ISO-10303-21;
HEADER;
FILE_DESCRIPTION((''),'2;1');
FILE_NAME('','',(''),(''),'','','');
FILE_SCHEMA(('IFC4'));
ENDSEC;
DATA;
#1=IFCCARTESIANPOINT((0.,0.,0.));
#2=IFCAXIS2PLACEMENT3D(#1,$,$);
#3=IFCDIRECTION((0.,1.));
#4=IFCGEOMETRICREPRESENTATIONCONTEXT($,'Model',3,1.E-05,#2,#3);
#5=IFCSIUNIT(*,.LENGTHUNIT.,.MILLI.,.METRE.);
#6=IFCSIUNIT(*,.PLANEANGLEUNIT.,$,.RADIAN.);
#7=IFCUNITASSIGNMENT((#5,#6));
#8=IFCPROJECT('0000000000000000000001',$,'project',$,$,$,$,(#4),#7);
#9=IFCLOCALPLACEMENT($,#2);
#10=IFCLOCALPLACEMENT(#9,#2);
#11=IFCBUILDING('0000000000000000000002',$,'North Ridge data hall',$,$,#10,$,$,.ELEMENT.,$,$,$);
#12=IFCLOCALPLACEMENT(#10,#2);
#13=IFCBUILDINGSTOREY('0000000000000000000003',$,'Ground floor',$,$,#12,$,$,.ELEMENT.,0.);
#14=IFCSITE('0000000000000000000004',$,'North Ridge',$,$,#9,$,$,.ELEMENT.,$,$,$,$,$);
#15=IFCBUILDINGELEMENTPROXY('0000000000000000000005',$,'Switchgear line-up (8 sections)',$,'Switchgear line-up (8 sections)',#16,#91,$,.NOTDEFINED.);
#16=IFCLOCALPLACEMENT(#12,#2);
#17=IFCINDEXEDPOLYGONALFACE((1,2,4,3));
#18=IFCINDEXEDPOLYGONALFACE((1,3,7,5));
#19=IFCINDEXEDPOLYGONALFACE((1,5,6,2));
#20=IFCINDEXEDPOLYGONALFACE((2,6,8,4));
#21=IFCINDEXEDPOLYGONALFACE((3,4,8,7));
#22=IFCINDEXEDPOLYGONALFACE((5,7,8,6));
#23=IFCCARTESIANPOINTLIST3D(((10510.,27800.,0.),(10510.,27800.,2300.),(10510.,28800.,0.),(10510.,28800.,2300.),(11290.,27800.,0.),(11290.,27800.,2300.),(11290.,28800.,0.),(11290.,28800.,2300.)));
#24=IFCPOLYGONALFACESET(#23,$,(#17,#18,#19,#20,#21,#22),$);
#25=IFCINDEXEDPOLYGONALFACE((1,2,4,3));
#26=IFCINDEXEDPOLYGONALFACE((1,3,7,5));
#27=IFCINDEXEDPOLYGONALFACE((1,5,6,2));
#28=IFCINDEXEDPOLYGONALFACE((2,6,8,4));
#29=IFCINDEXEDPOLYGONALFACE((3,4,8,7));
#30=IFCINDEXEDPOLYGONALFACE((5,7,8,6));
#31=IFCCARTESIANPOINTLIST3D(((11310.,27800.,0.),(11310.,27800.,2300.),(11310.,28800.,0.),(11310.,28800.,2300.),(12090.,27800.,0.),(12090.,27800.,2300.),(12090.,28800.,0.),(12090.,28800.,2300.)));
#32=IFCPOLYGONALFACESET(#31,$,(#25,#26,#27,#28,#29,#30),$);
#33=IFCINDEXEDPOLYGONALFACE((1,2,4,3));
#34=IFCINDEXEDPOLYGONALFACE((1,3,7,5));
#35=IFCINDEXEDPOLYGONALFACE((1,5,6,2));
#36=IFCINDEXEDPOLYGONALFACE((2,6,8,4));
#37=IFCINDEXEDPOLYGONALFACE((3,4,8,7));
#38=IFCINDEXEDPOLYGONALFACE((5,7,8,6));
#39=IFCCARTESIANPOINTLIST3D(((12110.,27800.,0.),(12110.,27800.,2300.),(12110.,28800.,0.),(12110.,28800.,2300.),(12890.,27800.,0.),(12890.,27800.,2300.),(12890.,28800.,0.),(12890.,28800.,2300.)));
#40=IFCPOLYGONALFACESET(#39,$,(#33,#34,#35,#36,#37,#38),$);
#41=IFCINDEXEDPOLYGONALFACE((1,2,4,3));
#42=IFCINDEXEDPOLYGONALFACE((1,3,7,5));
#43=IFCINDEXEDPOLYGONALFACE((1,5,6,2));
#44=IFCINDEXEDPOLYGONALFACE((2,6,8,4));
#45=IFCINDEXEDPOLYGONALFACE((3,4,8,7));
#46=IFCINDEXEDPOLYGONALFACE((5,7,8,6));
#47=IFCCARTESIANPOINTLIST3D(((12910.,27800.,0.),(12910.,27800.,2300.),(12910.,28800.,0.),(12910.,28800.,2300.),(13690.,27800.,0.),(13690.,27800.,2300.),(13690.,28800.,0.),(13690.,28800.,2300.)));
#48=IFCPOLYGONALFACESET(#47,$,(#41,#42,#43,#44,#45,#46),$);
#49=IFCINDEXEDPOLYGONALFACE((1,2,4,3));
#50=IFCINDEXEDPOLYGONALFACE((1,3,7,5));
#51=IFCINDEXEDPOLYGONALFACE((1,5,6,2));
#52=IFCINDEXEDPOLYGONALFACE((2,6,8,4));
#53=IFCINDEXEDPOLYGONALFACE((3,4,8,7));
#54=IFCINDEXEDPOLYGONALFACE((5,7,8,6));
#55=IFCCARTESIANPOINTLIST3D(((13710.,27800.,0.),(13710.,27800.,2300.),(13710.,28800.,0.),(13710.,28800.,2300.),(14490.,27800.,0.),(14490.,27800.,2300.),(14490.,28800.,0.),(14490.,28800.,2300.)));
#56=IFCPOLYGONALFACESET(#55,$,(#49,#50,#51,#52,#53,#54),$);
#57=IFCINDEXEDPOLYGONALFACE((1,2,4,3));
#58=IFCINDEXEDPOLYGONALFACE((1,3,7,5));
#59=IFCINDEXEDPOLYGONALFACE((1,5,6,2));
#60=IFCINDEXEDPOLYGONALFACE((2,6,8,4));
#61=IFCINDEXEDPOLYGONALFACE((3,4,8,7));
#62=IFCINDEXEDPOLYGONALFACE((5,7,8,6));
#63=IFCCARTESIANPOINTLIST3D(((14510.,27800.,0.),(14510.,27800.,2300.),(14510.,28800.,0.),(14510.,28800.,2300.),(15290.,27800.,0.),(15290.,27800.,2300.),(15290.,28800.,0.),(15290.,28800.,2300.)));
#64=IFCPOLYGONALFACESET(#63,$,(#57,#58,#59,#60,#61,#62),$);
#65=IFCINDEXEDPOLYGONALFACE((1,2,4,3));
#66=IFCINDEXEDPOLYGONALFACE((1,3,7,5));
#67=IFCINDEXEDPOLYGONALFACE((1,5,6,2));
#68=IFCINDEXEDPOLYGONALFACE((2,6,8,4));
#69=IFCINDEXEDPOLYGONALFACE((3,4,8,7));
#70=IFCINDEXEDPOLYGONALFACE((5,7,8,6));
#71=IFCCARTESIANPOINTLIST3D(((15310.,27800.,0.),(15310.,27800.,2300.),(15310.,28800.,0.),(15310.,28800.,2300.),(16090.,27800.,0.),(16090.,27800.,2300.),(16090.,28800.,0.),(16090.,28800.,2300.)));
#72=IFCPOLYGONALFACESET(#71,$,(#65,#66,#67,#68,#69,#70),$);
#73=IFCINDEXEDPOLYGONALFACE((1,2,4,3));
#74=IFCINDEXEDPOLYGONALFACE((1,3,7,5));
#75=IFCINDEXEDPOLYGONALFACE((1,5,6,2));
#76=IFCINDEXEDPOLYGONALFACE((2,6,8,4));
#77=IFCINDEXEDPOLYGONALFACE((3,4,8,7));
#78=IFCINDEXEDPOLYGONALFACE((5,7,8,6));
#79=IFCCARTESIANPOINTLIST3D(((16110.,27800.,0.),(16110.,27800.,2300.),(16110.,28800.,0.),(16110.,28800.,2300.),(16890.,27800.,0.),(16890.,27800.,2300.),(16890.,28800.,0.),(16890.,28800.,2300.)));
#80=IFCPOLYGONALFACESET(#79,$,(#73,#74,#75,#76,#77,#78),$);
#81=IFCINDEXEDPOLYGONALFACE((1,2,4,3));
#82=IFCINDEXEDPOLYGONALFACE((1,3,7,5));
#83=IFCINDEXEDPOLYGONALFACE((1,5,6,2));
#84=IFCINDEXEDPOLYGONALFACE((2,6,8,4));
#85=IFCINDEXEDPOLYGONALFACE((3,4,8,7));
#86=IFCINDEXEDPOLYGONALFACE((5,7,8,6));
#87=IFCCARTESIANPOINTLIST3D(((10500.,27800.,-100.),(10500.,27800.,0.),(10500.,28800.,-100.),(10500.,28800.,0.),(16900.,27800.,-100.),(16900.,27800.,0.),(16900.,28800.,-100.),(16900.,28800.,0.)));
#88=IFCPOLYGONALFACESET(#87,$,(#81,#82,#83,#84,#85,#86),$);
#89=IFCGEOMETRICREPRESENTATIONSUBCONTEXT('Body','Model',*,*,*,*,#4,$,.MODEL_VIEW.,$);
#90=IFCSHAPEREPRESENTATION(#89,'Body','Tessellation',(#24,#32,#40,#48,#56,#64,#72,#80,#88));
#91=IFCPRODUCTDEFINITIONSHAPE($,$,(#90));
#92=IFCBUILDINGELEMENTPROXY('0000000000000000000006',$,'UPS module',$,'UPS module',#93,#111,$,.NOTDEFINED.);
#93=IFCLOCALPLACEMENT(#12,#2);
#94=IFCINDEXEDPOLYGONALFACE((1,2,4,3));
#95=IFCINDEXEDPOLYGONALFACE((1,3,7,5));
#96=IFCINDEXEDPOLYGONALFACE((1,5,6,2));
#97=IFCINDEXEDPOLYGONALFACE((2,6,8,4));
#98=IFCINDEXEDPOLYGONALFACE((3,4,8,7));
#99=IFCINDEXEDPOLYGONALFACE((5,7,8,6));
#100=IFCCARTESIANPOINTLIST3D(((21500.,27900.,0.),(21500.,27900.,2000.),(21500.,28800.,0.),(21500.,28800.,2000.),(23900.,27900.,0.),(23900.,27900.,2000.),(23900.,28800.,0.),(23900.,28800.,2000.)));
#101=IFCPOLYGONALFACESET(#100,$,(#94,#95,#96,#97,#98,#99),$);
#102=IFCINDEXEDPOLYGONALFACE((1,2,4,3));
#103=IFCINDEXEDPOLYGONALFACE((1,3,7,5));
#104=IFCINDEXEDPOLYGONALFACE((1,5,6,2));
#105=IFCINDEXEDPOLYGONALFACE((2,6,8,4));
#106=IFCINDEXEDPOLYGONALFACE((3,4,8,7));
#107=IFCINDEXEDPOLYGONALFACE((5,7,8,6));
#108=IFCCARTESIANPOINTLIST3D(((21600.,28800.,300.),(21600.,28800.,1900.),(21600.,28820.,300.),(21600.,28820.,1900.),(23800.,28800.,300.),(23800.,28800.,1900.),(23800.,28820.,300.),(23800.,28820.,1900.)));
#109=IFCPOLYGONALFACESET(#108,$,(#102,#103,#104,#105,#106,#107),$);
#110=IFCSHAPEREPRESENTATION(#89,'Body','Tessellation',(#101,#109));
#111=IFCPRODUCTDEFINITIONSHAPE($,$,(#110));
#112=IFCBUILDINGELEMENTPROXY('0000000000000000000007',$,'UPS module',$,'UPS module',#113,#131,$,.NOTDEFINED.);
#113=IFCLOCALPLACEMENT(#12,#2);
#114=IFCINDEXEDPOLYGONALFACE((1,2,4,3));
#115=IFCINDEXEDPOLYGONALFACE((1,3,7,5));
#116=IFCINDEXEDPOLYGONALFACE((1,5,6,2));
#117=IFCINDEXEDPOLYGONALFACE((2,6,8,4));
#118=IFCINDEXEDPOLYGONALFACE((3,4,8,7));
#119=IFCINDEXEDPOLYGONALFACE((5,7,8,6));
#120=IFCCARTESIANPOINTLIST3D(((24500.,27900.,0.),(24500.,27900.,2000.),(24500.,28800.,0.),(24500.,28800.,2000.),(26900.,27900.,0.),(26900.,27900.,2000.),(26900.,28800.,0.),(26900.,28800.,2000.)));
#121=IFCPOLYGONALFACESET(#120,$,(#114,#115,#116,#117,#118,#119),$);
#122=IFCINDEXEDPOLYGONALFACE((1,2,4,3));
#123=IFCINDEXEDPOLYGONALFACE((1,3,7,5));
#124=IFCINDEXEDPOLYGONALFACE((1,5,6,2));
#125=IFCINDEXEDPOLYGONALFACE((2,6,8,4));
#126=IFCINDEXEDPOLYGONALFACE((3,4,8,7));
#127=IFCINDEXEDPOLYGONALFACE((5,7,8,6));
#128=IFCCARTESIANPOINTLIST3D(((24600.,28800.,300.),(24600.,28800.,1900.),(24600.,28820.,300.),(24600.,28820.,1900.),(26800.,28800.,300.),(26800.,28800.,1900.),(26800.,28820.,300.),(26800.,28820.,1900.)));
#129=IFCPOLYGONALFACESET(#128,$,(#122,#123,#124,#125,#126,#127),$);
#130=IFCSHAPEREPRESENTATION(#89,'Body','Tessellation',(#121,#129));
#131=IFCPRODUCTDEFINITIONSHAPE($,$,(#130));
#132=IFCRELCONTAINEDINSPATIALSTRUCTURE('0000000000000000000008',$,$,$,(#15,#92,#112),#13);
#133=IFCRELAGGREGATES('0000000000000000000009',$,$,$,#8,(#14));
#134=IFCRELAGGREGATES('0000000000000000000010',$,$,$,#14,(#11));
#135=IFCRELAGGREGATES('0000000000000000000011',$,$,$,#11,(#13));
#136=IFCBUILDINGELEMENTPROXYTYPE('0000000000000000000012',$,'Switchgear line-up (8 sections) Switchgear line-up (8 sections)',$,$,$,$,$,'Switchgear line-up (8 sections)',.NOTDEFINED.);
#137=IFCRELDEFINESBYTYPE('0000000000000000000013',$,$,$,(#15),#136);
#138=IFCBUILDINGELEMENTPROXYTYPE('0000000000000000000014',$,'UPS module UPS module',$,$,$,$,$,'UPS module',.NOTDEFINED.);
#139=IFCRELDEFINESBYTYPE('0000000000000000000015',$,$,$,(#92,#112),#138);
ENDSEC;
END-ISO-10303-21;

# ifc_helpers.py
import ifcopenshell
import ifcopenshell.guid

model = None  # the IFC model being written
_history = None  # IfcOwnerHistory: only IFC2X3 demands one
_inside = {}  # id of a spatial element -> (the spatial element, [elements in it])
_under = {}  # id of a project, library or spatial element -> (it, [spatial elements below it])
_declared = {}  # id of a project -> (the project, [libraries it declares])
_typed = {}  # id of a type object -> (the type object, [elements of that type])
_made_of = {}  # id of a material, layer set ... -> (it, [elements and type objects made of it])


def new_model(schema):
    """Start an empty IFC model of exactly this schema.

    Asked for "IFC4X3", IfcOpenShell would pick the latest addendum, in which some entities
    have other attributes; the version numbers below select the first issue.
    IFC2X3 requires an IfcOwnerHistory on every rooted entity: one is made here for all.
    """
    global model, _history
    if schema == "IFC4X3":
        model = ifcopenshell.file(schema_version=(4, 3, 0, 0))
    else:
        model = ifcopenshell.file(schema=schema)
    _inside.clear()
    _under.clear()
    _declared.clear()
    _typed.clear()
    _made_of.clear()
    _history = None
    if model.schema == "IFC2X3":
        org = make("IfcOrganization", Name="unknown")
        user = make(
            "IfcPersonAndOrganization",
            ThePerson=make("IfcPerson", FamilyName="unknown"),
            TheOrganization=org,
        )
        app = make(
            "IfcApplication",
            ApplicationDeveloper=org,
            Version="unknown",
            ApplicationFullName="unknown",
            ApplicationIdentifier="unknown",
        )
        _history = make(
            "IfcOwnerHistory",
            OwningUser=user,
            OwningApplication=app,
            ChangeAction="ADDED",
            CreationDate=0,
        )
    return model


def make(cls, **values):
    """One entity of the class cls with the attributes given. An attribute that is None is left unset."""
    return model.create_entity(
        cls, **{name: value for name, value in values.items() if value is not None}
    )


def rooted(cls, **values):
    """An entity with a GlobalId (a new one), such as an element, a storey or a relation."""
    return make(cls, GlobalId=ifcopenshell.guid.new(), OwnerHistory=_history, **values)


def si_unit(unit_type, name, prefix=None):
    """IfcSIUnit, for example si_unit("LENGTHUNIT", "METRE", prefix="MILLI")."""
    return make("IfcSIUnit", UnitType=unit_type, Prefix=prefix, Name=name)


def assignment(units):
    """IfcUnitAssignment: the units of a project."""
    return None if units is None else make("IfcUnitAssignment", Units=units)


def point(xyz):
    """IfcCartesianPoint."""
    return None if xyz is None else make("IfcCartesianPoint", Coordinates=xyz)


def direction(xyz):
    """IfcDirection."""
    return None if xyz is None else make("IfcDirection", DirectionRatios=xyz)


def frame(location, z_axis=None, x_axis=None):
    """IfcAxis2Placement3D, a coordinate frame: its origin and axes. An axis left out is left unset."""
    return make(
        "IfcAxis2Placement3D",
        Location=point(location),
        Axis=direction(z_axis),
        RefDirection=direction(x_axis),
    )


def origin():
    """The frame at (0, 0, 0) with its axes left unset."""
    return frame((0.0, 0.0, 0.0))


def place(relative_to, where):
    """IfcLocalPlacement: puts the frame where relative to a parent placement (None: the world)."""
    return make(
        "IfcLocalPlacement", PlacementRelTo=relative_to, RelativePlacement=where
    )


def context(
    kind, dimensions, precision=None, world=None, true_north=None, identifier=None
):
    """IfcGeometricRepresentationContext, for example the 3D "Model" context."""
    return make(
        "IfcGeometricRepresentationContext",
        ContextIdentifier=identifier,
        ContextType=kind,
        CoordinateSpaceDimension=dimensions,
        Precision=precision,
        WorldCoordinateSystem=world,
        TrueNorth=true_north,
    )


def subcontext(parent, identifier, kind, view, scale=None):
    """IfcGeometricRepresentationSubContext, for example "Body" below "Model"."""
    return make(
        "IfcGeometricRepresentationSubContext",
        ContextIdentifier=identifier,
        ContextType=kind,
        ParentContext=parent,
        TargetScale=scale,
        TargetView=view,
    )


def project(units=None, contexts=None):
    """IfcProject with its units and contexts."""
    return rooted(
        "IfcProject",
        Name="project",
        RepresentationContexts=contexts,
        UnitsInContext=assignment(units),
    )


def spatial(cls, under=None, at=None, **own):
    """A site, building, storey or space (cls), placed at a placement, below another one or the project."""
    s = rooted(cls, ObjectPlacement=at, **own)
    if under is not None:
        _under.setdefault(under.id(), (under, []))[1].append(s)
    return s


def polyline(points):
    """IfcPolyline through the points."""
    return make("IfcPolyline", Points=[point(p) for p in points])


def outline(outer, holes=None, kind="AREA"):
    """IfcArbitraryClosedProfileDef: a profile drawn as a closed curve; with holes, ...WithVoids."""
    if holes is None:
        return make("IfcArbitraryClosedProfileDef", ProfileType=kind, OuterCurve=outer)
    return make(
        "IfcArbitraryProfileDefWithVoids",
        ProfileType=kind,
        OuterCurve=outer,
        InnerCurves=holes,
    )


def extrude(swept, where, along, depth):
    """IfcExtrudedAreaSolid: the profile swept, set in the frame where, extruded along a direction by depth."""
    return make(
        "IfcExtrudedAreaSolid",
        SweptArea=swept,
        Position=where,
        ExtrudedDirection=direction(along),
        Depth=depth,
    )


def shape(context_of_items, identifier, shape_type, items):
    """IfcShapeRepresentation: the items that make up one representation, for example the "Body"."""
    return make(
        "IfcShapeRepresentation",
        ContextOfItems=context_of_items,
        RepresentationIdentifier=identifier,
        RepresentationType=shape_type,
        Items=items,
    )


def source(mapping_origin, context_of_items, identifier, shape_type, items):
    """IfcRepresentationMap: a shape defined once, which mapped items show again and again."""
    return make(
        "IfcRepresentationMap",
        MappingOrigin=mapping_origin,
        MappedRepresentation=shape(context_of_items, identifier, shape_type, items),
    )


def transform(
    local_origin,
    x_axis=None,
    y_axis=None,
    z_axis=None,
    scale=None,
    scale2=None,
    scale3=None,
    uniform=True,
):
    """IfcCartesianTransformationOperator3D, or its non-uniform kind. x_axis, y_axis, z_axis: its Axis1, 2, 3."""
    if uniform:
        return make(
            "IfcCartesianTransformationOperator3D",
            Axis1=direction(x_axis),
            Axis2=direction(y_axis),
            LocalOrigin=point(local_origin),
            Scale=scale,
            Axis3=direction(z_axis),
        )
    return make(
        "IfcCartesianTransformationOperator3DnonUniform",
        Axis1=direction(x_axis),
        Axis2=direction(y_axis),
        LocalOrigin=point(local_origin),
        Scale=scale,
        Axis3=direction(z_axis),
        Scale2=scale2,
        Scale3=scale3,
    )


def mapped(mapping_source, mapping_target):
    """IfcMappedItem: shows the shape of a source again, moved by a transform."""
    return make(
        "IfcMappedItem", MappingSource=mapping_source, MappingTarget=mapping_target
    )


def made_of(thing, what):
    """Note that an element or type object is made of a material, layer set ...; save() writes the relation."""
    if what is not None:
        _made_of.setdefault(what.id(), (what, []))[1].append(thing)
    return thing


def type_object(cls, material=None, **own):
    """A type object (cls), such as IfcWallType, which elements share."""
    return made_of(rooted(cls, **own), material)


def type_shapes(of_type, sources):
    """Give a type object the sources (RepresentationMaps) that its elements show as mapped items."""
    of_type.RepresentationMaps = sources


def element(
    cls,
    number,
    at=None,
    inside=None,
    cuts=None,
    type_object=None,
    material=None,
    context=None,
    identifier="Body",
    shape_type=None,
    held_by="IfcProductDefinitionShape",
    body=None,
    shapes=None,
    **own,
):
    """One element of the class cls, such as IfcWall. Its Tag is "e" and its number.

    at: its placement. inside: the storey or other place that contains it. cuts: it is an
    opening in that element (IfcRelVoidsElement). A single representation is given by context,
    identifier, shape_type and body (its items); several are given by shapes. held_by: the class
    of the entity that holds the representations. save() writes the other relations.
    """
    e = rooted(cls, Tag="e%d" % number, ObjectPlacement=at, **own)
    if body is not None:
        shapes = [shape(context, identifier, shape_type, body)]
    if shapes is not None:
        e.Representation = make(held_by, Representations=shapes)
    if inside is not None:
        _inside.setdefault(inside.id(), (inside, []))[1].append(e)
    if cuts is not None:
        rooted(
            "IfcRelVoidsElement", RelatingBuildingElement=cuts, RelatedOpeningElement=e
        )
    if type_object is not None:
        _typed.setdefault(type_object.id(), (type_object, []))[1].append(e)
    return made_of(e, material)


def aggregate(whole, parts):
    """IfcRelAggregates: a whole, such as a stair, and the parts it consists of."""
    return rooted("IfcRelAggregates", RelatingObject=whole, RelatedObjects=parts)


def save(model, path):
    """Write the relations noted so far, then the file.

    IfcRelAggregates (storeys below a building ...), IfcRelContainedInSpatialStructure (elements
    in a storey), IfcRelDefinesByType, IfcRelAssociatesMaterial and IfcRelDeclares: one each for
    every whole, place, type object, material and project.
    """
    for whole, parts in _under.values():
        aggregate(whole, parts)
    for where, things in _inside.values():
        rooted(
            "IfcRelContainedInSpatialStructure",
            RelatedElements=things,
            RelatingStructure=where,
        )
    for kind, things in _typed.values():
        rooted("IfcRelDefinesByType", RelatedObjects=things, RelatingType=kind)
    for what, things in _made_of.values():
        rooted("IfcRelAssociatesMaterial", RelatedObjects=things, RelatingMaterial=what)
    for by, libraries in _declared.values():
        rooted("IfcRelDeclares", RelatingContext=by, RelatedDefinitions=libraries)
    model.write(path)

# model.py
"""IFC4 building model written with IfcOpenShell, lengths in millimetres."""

from ifc_helpers import new_model, si_unit, direction, frame, origin, place, context, subcontext, project, spatial, polyline, outline, extrude, source, transform, mapped, type_object, type_shapes, element, save


model = new_model("IFC4")

# Units and contexts
model_context = context("Model", 3, precision=1e-05, world=origin(), true_north=direction((0.0, 1.0)))
body_context = subcontext(model_context, "Body", "Model", "MODEL_VIEW")
ifc_project = project(units=[si_unit("LENGTHUNIT", "METRE", prefix="MILLI"), si_unit("PLANEANGLEUNIT", "RADIAN")], contexts=[model_context])

# Site, building, storey
site_placement = place(None, origin())
site = spatial("IfcSite", under=ifc_project, at=site_placement, Name="North Ridge", CompositionType="ELEMENT")
building_placement = place(site_placement, origin())
building = spatial("IfcBuilding", under=site, at=building_placement, Name="North Ridge data hall", CompositionType="ELEMENT")
storey_placement = place(building_placement, origin())
storey = spatial("IfcBuildingStorey", under=building, at=storey_placement, Name="Ground floor", CompositionType="ELEMENT", Elevation=0.0)

# Building element proxies
building_element_proxy_type_1 = type_object("IfcBuildingElementProxyType", Name="Switchgear line-up (8 sections) Switchgear line-up (8 sections)", ElementType="Switchgear line-up (8 sections)", PredefinedType="NOTDEFINED")
shared_shape_1 = source(origin(), body_context, "Body", "SweptSolid", [
    extrude(outline(polyline([(10.0, 0.0), (790.0, 0.0), (790.0, 1000.0), (10.0, 1000.0), (10.0, 0.0)])), origin(), (0.0, 0.0, 1.0), 2300.0),
    extrude(outline(polyline([(810.0, 0.0), (1590.0, 0.0), (1590.0, 1000.0), (810.0, 1000.0), (810.0, 0.0)])), origin(), (0.0, 0.0, 1.0), 2300.0),
    extrude(outline(polyline([(1610.0, 0.0), (2390.0, 0.0), (2390.0, 1000.0), (1610.0, 1000.0), (1610.0, 0.0)])), origin(), (0.0, 0.0, 1.0), 2300.0),
    extrude(outline(polyline([(2410.0, 0.0), (3190.0, 0.0), (3190.0, 1000.0), (2410.0, 1000.0), (2410.0, 0.0)])), origin(), (0.0, 0.0, 1.0), 2300.0),
    extrude(outline(polyline([(3210.0, 0.0), (3990.0, 0.0), (3990.0, 1000.0), (3210.0, 1000.0), (3210.0, 0.0)])), origin(), (0.0, 0.0, 1.0), 2300.0),
    extrude(outline(polyline([(4010.0, 0.0), (4790.0, 0.0), (4790.0, 1000.0), (4010.0, 1000.0), (4010.0, 0.0)])), origin(), (0.0, 0.0, 1.0), 2300.0),
    extrude(outline(polyline([(4810.0, 0.0), (5590.0, 0.0), (5590.0, 1000.0), (4810.0, 1000.0), (4810.0, 0.0)])), origin(), (0.0, 0.0, 1.0), 2300.0),
    extrude(outline(polyline([(5610.0, 0.0), (6390.0, 0.0), (6390.0, 1000.0), (5610.0, 1000.0), (5610.0, 0.0)])), origin(), (0.0, 0.0, 1.0), 2300.0),
    extrude(outline(polyline([(0.0, 0.0), (6400.0, 0.0), (6400.0, 1000.0), (0.0, 1000.0), (0.0, 0.0)])), frame((0.0, 0.0, -100.0)), (0.0, 0.0, 1.0), 100.0),
])
type_shapes(building_element_proxy_type_1, [shared_shape_1])
for number, where, z_axis, x_axis, name in (
    (1, (10500.0, 27800.0, 0.0), (0.0, 0.0, 1.0), (1.0, 0.0, 0.0), "Switchgear line-up (8 sections)"),
):
    element("IfcBuildingElementProxy", number, at=place(storey_placement, frame(where, z_axis=z_axis, x_axis=x_axis)), inside=storey, type_object=building_element_proxy_type_1, Name=name, ObjectType="Switchgear line-up (8 sections)", PredefinedType="NOTDEFINED", context=body_context, shape_type="MappedRepresentation", body=[
        mapped(shared_shape_1, transform((0.0, 0.0, 0.0))),
    ])
building_element_proxy_type_2 = type_object("IfcBuildingElementProxyType", Name="UPS module UPS module", ElementType="UPS module", PredefinedType="NOTDEFINED")
shared_shape_2 = source(origin(), body_context, "Body", "SweptSolid", [
    extrude(outline(polyline([(0.0, 0.0), (2400.0, 0.0), (2400.0, 900.0), (0.0, 900.0), (0.0, 0.0)])), origin(), (0.0, 0.0, 1.0), 2000.0),
    extrude(outline(polyline([(100.0, 900.0), (2300.0, 900.0), (2300.0, 920.0), (100.0, 920.0), (100.0, 900.0)])), frame((0.0, 0.0, 300.0)), (0.0, 0.0, 1.0), 1600.0),
])
type_shapes(building_element_proxy_type_2, [shared_shape_2])
for number, where, z_axis, x_axis, name in (
    (2, (21500.0, 27900.0, 0.0), (0.0, 0.0, 1.0), (1.0, 0.0, 0.0), "UPS module"),
    (3, (24500.0, 27900.0, 0.0), (0.0, 0.0, 1.0), (1.0, 0.0, 0.0), "UPS module"),
):
    element("IfcBuildingElementProxy", number, at=place(storey_placement, frame(where, z_axis=z_axis, x_axis=x_axis)), inside=storey, type_object=building_element_proxy_type_2, Name=name, ObjectType="UPS module", PredefinedType="NOTDEFINED", context=body_context, shape_type="MappedRepresentation", body=[
        mapped(shared_shape_2, transform((0.0, 0.0, 0.0))),
    ])

save(model, "model.ifc")
